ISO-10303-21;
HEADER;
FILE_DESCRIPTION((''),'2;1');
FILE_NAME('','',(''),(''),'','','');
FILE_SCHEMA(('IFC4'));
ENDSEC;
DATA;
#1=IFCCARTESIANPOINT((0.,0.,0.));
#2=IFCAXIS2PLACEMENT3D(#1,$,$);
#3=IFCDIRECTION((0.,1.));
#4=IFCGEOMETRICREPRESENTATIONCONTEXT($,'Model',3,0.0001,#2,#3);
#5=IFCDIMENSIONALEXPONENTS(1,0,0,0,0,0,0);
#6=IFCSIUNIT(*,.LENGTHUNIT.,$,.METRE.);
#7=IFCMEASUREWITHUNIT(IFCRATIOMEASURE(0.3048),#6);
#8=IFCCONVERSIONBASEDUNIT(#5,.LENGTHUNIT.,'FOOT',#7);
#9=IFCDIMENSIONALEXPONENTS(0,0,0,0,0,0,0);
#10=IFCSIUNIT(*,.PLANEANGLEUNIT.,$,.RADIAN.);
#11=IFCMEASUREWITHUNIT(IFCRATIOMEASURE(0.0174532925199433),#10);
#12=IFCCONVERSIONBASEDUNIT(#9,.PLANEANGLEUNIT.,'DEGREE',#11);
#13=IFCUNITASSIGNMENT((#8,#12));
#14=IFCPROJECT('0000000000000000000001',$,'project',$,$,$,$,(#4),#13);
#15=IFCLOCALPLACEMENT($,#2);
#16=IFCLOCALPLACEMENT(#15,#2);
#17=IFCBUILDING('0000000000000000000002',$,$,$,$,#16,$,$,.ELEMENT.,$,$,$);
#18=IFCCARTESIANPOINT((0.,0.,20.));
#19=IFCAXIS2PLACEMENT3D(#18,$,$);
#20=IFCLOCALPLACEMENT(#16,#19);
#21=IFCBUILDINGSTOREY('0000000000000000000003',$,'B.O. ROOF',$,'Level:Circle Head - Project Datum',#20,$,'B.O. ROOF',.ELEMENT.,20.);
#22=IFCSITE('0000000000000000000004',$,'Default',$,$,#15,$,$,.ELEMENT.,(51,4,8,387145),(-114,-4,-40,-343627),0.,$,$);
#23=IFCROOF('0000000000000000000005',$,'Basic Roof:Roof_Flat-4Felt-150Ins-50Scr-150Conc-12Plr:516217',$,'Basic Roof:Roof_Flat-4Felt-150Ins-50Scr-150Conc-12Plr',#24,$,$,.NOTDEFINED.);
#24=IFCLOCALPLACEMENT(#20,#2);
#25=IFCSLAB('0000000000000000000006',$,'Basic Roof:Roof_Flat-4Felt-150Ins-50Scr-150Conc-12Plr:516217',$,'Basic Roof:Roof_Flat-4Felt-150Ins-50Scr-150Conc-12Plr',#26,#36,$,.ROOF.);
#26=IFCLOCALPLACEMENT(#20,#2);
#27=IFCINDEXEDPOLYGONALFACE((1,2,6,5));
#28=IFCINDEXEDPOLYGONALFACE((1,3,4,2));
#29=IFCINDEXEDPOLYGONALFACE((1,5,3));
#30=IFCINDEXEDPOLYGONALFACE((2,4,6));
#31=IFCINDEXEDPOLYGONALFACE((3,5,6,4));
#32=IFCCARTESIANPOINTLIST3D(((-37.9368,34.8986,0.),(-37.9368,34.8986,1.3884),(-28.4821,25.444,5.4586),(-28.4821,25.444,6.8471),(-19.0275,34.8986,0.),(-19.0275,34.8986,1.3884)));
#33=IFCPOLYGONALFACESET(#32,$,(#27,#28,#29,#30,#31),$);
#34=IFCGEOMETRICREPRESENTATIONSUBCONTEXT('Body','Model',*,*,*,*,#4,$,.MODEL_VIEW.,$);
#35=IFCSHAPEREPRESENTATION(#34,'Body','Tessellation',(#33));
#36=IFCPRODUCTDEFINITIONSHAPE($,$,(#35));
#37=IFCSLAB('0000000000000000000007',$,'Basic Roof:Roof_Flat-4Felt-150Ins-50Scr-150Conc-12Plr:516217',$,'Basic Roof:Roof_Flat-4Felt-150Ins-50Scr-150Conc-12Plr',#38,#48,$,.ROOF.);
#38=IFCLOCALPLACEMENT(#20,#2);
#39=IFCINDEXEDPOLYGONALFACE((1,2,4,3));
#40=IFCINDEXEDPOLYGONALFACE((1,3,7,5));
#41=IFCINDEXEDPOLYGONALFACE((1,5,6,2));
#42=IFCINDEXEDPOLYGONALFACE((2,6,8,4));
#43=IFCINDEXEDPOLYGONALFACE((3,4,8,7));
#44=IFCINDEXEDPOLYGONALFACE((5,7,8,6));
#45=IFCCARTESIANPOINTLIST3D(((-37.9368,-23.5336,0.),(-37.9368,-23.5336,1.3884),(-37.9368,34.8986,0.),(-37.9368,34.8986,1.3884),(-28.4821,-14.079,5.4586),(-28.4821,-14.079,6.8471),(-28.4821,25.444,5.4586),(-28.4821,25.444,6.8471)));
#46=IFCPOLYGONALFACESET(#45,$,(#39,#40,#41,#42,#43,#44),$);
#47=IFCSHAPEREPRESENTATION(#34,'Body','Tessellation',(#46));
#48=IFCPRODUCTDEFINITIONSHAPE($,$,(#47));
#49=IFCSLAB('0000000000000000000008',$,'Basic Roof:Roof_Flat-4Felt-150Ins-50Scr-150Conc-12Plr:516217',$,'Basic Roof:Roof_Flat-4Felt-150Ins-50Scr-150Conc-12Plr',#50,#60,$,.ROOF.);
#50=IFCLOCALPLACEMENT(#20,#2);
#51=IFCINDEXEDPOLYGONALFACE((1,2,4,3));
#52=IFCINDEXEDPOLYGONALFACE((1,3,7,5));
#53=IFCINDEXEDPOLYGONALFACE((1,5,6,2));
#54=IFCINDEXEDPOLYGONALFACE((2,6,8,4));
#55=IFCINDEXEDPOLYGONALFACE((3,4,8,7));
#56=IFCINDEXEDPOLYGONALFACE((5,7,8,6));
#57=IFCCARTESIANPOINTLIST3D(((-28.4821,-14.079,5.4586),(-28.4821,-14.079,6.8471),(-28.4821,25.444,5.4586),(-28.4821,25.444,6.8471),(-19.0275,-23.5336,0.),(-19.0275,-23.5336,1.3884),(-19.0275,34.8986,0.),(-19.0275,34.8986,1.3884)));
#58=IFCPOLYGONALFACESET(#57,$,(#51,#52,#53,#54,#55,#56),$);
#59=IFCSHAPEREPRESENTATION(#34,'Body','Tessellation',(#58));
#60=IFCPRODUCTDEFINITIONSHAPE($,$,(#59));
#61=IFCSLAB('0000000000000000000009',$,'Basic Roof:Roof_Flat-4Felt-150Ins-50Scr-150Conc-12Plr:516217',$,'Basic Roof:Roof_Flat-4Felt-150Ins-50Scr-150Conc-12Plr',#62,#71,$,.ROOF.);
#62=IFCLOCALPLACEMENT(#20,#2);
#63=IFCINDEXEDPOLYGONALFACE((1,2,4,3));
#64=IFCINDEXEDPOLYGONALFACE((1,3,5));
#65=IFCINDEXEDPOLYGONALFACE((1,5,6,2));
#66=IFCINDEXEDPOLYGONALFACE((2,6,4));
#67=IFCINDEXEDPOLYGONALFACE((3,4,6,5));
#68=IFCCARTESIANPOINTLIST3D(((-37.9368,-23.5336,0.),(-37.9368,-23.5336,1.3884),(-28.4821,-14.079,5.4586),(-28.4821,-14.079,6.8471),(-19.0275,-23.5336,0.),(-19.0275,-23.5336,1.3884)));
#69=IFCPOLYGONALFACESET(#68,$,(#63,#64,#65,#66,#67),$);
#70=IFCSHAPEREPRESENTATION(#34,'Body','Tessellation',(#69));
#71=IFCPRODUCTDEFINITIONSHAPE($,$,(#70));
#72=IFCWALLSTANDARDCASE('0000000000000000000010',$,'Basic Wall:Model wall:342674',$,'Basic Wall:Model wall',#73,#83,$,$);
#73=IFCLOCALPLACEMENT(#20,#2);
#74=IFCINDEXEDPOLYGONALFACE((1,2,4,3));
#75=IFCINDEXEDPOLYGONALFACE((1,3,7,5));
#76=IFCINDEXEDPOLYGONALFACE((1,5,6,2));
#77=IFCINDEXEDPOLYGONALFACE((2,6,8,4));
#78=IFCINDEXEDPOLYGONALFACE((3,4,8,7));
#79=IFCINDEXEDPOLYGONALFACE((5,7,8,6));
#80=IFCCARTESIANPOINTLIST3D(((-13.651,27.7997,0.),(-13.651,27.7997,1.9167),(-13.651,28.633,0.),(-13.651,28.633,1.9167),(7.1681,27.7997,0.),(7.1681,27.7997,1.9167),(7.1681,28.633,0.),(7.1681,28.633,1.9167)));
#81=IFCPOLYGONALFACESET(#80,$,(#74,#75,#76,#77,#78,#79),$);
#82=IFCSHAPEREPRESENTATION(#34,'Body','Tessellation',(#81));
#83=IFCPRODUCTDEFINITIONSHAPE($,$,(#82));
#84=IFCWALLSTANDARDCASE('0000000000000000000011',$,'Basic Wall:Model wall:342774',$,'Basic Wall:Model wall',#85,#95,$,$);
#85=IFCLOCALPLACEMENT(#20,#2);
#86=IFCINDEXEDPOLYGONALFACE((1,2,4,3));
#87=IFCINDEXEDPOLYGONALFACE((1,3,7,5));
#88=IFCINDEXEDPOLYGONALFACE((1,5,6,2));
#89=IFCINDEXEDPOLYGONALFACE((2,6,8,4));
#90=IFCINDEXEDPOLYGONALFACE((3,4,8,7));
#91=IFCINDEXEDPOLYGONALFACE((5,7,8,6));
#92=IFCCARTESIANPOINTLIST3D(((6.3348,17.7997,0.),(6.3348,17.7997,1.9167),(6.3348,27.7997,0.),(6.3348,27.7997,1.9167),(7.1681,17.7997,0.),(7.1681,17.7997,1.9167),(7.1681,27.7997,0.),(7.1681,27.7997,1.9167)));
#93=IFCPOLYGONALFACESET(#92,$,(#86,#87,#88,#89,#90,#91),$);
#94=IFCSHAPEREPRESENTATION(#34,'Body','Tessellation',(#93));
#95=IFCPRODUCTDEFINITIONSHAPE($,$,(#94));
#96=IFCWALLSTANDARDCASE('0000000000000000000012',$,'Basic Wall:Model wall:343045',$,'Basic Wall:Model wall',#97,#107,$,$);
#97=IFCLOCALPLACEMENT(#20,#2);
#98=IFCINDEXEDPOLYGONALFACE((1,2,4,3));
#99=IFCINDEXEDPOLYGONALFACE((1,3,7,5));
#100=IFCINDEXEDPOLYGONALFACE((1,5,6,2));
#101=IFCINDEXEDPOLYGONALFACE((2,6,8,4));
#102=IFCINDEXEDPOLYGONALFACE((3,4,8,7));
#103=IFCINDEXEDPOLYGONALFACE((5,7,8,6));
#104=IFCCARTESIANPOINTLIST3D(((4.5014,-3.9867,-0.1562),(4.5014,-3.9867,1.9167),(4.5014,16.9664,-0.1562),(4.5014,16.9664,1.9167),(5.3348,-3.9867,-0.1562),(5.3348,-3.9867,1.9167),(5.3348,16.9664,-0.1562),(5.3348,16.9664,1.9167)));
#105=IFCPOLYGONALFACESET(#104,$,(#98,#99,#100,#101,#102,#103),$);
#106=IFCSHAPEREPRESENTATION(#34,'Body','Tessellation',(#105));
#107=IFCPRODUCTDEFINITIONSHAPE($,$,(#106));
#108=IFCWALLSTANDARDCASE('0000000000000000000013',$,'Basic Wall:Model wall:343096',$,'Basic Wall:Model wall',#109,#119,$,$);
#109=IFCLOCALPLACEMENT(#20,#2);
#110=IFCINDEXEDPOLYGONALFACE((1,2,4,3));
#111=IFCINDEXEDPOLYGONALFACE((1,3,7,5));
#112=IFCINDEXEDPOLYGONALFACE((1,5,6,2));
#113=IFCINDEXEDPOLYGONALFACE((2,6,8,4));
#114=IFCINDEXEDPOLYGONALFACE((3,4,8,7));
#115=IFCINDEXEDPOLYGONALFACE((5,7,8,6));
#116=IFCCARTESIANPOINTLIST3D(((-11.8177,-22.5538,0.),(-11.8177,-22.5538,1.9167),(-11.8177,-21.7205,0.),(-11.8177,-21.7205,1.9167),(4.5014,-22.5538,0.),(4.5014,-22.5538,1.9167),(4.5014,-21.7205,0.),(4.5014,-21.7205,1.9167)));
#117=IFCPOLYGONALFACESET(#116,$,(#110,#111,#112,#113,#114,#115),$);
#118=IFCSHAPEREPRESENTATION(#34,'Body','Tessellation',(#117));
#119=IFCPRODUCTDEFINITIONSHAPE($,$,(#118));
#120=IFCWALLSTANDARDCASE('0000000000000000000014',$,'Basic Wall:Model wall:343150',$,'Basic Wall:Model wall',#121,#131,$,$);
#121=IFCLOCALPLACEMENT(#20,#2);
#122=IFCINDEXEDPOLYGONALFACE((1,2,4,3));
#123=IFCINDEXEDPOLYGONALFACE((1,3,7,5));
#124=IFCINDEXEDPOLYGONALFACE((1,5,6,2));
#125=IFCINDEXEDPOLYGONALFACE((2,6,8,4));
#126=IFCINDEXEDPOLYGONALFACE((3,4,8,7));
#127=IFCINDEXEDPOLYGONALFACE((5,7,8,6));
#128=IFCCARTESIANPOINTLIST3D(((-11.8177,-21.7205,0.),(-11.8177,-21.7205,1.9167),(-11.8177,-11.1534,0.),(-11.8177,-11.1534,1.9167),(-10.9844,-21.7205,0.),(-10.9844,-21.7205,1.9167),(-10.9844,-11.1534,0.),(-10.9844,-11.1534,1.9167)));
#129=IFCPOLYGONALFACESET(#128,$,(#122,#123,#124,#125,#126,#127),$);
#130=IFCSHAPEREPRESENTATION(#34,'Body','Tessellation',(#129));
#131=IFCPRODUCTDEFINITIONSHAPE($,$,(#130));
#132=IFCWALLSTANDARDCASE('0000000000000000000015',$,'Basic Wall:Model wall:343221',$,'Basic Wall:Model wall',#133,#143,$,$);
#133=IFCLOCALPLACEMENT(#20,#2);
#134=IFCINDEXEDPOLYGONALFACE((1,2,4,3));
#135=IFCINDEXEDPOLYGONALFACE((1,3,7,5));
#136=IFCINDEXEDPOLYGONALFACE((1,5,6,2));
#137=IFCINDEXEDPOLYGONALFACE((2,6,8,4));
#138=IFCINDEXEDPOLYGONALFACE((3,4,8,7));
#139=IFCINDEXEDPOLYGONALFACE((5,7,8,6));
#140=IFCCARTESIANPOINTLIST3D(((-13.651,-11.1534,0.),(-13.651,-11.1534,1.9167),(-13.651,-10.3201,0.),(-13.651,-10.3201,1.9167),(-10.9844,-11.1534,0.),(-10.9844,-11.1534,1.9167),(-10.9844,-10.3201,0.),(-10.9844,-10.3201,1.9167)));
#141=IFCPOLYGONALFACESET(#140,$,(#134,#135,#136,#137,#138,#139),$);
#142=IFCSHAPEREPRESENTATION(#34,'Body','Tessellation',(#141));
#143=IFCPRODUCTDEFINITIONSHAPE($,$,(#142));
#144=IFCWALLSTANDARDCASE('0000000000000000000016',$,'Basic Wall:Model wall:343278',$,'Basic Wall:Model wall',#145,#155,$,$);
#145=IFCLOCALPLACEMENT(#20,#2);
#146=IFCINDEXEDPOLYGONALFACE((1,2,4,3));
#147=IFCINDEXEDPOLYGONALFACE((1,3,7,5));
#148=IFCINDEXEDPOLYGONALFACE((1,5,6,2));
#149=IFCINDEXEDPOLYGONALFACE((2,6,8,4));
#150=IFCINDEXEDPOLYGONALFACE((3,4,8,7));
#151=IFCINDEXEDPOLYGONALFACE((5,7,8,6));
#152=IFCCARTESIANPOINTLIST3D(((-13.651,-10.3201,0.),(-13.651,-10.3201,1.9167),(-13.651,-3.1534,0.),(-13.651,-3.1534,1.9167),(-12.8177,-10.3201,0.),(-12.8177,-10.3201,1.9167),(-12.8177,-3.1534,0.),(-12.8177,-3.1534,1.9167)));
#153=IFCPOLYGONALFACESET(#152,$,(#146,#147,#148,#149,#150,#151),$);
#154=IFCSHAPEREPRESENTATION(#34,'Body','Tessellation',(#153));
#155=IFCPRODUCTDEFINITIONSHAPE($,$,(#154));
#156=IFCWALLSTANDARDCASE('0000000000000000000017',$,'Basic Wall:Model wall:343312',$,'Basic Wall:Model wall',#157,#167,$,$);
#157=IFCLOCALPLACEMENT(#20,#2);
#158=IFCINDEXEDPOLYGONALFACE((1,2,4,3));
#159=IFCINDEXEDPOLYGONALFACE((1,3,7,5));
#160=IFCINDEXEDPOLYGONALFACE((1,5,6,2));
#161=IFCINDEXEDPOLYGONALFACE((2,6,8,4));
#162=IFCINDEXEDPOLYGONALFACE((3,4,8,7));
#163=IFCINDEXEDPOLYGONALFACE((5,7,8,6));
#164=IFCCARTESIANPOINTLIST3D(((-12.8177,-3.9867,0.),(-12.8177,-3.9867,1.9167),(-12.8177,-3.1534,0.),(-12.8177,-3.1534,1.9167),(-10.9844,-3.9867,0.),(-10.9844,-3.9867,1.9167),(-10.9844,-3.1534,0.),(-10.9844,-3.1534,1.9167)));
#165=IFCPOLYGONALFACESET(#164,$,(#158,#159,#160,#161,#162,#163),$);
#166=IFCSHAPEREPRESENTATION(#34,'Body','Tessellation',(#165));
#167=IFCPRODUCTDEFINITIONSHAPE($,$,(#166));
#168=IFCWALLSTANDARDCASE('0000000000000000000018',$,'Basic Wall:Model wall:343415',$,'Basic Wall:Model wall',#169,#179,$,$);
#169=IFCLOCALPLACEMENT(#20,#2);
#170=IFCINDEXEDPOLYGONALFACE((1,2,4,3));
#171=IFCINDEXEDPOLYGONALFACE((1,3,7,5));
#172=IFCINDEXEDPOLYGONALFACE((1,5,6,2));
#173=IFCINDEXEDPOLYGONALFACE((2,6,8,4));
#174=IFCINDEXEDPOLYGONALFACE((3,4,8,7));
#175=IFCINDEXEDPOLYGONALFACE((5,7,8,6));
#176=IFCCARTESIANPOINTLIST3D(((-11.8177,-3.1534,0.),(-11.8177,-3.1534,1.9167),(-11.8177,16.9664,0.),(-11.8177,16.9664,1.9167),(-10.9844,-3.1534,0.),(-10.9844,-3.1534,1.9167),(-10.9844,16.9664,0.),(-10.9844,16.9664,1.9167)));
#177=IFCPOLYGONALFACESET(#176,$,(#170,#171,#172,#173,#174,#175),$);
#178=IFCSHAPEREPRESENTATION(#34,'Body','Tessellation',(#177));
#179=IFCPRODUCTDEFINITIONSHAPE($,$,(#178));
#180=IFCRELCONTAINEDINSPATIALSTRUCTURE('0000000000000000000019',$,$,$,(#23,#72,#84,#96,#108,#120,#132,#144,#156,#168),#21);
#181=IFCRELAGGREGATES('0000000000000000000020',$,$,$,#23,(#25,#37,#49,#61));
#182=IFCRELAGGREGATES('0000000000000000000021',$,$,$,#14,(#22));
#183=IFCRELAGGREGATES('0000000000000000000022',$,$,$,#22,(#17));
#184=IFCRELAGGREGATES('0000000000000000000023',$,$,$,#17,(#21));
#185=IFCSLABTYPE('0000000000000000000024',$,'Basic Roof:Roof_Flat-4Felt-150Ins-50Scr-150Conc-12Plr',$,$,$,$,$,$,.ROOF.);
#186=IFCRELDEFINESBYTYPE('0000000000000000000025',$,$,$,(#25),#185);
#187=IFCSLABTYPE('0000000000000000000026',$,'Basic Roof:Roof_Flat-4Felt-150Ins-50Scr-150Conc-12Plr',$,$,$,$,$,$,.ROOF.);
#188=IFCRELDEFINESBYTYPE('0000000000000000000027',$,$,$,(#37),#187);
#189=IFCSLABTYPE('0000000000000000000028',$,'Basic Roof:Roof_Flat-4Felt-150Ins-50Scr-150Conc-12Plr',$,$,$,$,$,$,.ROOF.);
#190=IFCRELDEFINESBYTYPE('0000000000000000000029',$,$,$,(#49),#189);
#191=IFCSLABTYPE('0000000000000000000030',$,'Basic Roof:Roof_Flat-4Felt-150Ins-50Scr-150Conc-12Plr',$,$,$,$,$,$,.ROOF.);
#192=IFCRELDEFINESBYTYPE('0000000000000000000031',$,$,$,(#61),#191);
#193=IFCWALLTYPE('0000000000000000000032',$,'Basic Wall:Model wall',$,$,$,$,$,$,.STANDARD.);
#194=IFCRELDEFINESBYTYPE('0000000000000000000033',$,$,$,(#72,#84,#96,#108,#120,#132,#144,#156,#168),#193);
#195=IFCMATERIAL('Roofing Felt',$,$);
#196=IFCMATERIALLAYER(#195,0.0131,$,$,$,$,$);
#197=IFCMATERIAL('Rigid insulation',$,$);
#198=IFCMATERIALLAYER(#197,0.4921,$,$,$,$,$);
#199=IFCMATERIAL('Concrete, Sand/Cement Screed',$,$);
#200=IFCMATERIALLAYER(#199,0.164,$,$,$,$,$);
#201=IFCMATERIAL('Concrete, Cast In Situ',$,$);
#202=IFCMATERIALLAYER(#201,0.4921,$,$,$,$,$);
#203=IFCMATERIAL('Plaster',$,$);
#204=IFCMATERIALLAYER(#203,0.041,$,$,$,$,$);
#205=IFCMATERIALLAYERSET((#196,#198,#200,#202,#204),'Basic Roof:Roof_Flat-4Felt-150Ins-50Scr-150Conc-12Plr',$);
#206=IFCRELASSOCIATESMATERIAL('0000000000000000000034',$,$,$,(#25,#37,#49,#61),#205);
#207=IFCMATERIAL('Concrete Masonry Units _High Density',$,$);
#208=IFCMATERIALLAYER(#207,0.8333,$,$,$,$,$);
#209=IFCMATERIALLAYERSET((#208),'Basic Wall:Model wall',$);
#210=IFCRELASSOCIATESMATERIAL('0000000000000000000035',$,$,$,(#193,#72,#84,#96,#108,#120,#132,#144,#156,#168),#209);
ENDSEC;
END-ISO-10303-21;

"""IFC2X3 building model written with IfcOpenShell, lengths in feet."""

from ifc_helpers import new_model, entity, si_unit, converted_unit, direction, frame, frame_2d, origin, place, context, subcontext, project, spatial, polyline, rectangle, outline, extrude, material, layer, layer_set, layer_usage, type_object, element, aggregate, save


model = new_model("IFC2X3")

# Units and contexts
model_context = context("Model", 3, precision=0.0001, world=origin(), true_north=direction((0.0, 1.0)))
body_context = subcontext(model_context, "Body", "Model", "MODEL_VIEW")
ifc_project = project(units=[converted_unit("LENGTHUNIT", "FOOT", entity("IfcRatioMeasure", 0.3048), si_unit("LENGTHUNIT", "METRE"), dimensions=[1, 0, 0, 0, 0, 0, 0]), converted_unit("PLANEANGLEUNIT", "DEGREE", entity("IfcRatioMeasure", 0.0174532925199433), si_unit("PLANEANGLEUNIT", "RADIAN"), dimensions=[0, 0, 0, 0, 0, 0, 0])], contexts=[model_context])

# Site, building, storey
site_placement = place(None, origin())
site = spatial("IfcSite", under=ifc_project, at=site_placement, Name="Default", CompositionType="ELEMENT", RefLatitude=(51, 4, 8, 387145), RefLongitude=(-114, -4, -40, -343627), RefElevation=0.0)
building_placement = place(site_placement, origin())
building = spatial("IfcBuilding", under=site, at=building_placement, CompositionType="ELEMENT")
storey_placement = place(building_placement, frame((0.0, 0.0, 20.0)))
storey = spatial("IfcBuildingStorey", under=building, at=storey_placement, Name="B.O. ROOF", ObjectType="Level:Circle Head - Project Datum", LongName="B.O. ROOF", CompositionType="ELEMENT", Elevation=20.0)

# Shared definitions
ifc_material_1 = material(Name="Rigid insulation")

# Roof, slabs
roof_1_placement = place(storey_placement, frame((-37.9368, -23.5336, 0.0)))
roof_1 = element("IfcRoof", 1, at=roof_1_placement, inside=storey, Name="Basic Roof:Roof_Flat-4Felt-150Ins-50Scr-150Conc-12Plr:516217", ObjectType="Basic Roof:Roof_Flat-4Felt-150Ins-50Scr-150Conc-12Plr", ShapeType="NOTDEFINED")
ifc_material_2 = material(Name="Roofing Felt")
ifc_layer_1 = layer(ifc_material_2, 0.0131)
ifc_layer_2 = layer(ifc_material_1, 0.4921)
ifc_material_3 = material(Name="Concrete, Sand/Cement Screed")
ifc_layer_3 = layer(ifc_material_3, 0.164)
ifc_material_4 = material(Name="Concrete, Cast In Situ")
ifc_layer_4 = layer(ifc_material_4, 0.4921)
ifc_material_5 = material(Name="Plaster")
ifc_layer_5 = layer(ifc_material_5, 0.041)
ifc_layer_set_1 = layer_set([ifc_layer_1, ifc_layer_2, ifc_layer_3, ifc_layer_4, ifc_layer_5], Name="Basic Roof:Roof_Flat-4Felt-150Ins-50Scr-150Conc-12Plr")
slab_type_1 = type_object("IfcSlabType", Name="Basic Roof:Roof_Flat-4Felt-150Ins-50Scr-150Conc-12Plr", PredefinedType="ROOF")
slab_1_placement = place(roof_1_placement, origin())
slab_1 = element("IfcSlab", 2, at=slab_1_placement, type_object=slab_type_1, material=ifc_layer_set_1, Name="Basic Roof:Roof_Flat-4Felt-150Ins-50Scr-150Conc-12Plr:516217", ObjectType="Basic Roof:Roof_Flat-4Felt-150Ins-50Scr-150Conc-12Plr", PredefinedType="ROOF", context=body_context, shape_type="SweptSolid", body=[
    extrude(outline(polyline([(9.4547, 5.4586), (-9.4547, 5.4586), (0.0, -5.4586), (9.4547, 5.4586)])), frame((9.4547, 53.7049, 2.7293), z_axis=(0.0, 0.5, 0.866025), x_axis=(1.0, 0.0, 0.0)), (0.0, -0.5, 0.866025), 1.3884),
])
slab_type_2 = type_object("IfcSlabType", Name="Basic Roof:Roof_Flat-4Felt-150Ins-50Scr-150Conc-12Plr", PredefinedType="ROOF")
slab_2_placement = place(roof_1_placement, origin())
slab_2 = element("IfcSlab", 3, at=slab_2_placement, type_object=slab_type_2, material=ifc_layer_set_1, Name="Basic Roof:Roof_Flat-4Felt-150Ins-50Scr-150Conc-12Plr:516217", ObjectType="Basic Roof:Roof_Flat-4Felt-150Ins-50Scr-150Conc-12Plr", PredefinedType="ROOF", context=body_context, shape_type="SweptSolid", body=[
    extrude(outline(polyline([(-5.4586, 29.2161), (-5.4586, -29.2161), (5.4586, -19.7615), (5.4586, 19.7615), (-5.4586, 29.2161)])), frame((4.7273, 29.2161, 2.7293), z_axis=(-0.5, 0.0, 0.866025), x_axis=(0.866025, 0.0, 0.5)), (0.5, 0.0, 0.866025), 1.3884),
])
slab_type_3 = type_object("IfcSlabType", Name="Basic Roof:Roof_Flat-4Felt-150Ins-50Scr-150Conc-12Plr", PredefinedType="ROOF")
slab_3_placement = place(roof_1_placement, origin())
slab_3 = element("IfcSlab", 4, at=slab_3_placement, type_object=slab_type_3, material=ifc_layer_set_1, Name="Basic Roof:Roof_Flat-4Felt-150Ins-50Scr-150Conc-12Plr:516217", ObjectType="Basic Roof:Roof_Flat-4Felt-150Ins-50Scr-150Conc-12Plr", PredefinedType="ROOF", context=body_context, shape_type="SweptSolid", body=[
    extrude(outline(polyline([(-5.4586, 19.7615), (-5.4586, -19.7615), (5.4586, -29.2161), (5.4586, 29.2161), (-5.4586, 19.7615)])), frame((14.182, 29.2161, 2.7293), z_axis=(0.5, 0.0, 0.866025), x_axis=(0.866025, 0.0, -0.5)), (-0.5, 0.0, 0.866025), 1.3884),
])
slab_type_4 = type_object("IfcSlabType", Name="Basic Roof:Roof_Flat-4Felt-150Ins-50Scr-150Conc-12Plr", PredefinedType="ROOF")
slab_4_placement = place(roof_1_placement, origin())
slab_4 = element("IfcSlab", 5, at=slab_4_placement, type_object=slab_type_4, material=ifc_layer_set_1, Name="Basic Roof:Roof_Flat-4Felt-150Ins-50Scr-150Conc-12Plr:516217", ObjectType="Basic Roof:Roof_Flat-4Felt-150Ins-50Scr-150Conc-12Plr", PredefinedType="ROOF", context=body_context, shape_type="SweptSolid", body=[
    extrude(outline(polyline([(-9.4547, -5.4586), (9.4547, -5.4586), (0.0, 5.4586), (-9.4547, -5.4586)])), frame((9.4547, 4.7273, 2.7293), z_axis=(0.0, -0.5, 0.866025), x_axis=(1.0, 0.0, 0.0)), (0.0, 0.5, 0.866025), 1.3884),
])
aggregate(roof_1, [slab_1, slab_2, slab_3, slab_4])

# Walls
ifc_material_6 = material(Name="Concrete Masonry Units _High Density")
ifc_layer_6 = layer(ifc_material_6, 0.8333)
ifc_layer_set_2 = layer_set([ifc_layer_6], Name="Basic Wall:Model wall")
ifc_layer_usage_1 = layer_usage(ifc_layer_set_2, "AXIS2", "NEGATIVE", 0.4167)
wall_type = type_object("IfcWallType", Name="Basic Wall:Model wall", PredefinedType="STANDARD", material=ifc_layer_set_2)
wall_1_placement = place(storey_placement, frame((-13.651, 28.2164, 0.0)))
element("IfcWallStandardCase", 6, at=wall_1_placement, inside=storey, type_object=wall_type, material=ifc_layer_usage_1, Name="Basic Wall:Model wall:342674", ObjectType="Basic Wall:Model wall", context=body_context, shape_type="SweptSolid", body=[
    extrude(rectangle(XDim=20.8192, YDim=0.8333, at=frame_2d((10.4096, 0.0), x_axis=(-1.0, 0.0))), origin(), (0.0, 0.0, 1.0), 1.9167),
])
ifc_layer_usage_2 = layer_usage(ifc_layer_set_2, "AXIS2", "NEGATIVE", 0.4167)
wall_2_placement = place(storey_placement, frame((6.7514, 27.7997, 0.0), z_axis=(0.0, 0.0, 1.0), x_axis=(0.0, -1.0, 0.0)))
element("IfcWallStandardCase", 7, at=wall_2_placement, inside=storey, type_object=wall_type, material=ifc_layer_usage_2, Name="Basic Wall:Model wall:342774", ObjectType="Basic Wall:Model wall", context=body_context, shape_type="SweptSolid", body=[
    extrude(rectangle(XDim=10.0, YDim=0.8333, at=frame_2d((5.0, 0.0), x_axis=(-1.0, 0.0))), origin(), (0.0, 0.0, 1.0), 1.9167),
])
ifc_layer_usage_3 = layer_usage(ifc_layer_set_2, "AXIS2", "NEGATIVE", 0.4167)
wall_3_placement = place(storey_placement, frame((4.9181, 16.9664, -0.1562), z_axis=(0.0, 0.0, 1.0), x_axis=(0.0, -1.0, 0.0)))
element("IfcWallStandardCase", 8, at=wall_3_placement, inside=storey, type_object=wall_type, material=ifc_layer_usage_3, Name="Basic Wall:Model wall:343045", ObjectType="Basic Wall:Model wall", context=body_context, shape_type="SweptSolid", body=[
    extrude(rectangle(XDim=20.9531, YDim=0.8333, at=frame_2d((10.4766, 0.0), x_axis=(-1.0, 0.0))), origin(), (0.0, 0.0, 1.0), 2.0728),
])
ifc_layer_usage_4 = layer_usage(ifc_layer_set_2, "AXIS2", "NEGATIVE", 0.4167)
wall_4_placement = place(storey_placement, frame((4.5014, -22.1371, 0.0), z_axis=(0.0, 0.0, 1.0), x_axis=(-1.0, 0.0, 0.0)))
element("IfcWallStandardCase", 9, at=wall_4_placement, inside=storey, type_object=wall_type, material=ifc_layer_usage_4, Name="Basic Wall:Model wall:343096", ObjectType="Basic Wall:Model wall", context=body_context, shape_type="SweptSolid", body=[
    extrude(rectangle(XDim=16.3192, YDim=0.8333, at=frame_2d((8.1596, 0.0), x_axis=(-1.0, 0.0))), origin(), (0.0, 0.0, 1.0), 1.9167),
])
ifc_layer_usage_5 = layer_usage(ifc_layer_set_2, "AXIS2", "NEGATIVE", 0.4167)
wall_5_placement = place(storey_placement, frame((-11.401, -21.7205, 0.0), z_axis=(0.0, 0.0, 1.0), x_axis=(0.0, 1.0, 0.0)))
element("IfcWallStandardCase", 10, at=wall_5_placement, inside=storey, type_object=wall_type, material=ifc_layer_usage_5, Name="Basic Wall:Model wall:343150", ObjectType="Basic Wall:Model wall", context=body_context, shape_type="SweptSolid", body=[
    extrude(rectangle(XDim=10.5671, YDim=0.8333, at=frame_2d((5.2835, 0.0), x_axis=(-1.0, 0.0))), origin(), (0.0, 0.0, 1.0), 1.9167),
])
ifc_layer_usage_6 = layer_usage(ifc_layer_set_2, "AXIS2", "NEGATIVE", 0.4167)
wall_6_placement = place(storey_placement, frame((-10.9844, -10.7367, 0.0), z_axis=(0.0, 0.0, 1.0), x_axis=(-1.0, 0.0, 0.0)))
element("IfcWallStandardCase", 11, at=wall_6_placement, inside=storey, type_object=wall_type, material=ifc_layer_usage_6, Name="Basic Wall:Model wall:343221", ObjectType="Basic Wall:Model wall", context=body_context, shape_type="SweptSolid", body=[
    extrude(rectangle(XDim=2.6667, YDim=0.8333, at=frame_2d((1.3333, 0.0), x_axis=(-1.0, 0.0))), origin(), (0.0, 0.0, 1.0), 1.9167),
])
ifc_layer_usage_7 = layer_usage(ifc_layer_set_2, "AXIS2", "NEGATIVE", 0.4167)
wall_7_placement = place(storey_placement, frame((-13.2344, -10.3201, 0.0), z_axis=(0.0, 0.0, 1.0), x_axis=(0.0, 1.0, 0.0)))
element("IfcWallStandardCase", 12, at=wall_7_placement, inside=storey, type_object=wall_type, material=ifc_layer_usage_7, Name="Basic Wall:Model wall:343278", ObjectType="Basic Wall:Model wall", context=body_context, shape_type="SweptSolid", body=[
    extrude(rectangle(XDim=7.1667, YDim=0.8333, at=frame_2d((3.5833, 0.0), x_axis=(-1.0, 0.0))), origin(), (0.0, 0.0, 1.0), 1.9167),
])
ifc_layer_usage_8 = layer_usage(ifc_layer_set_2, "AXIS2", "NEGATIVE", 0.4167)
wall_8_placement = place(storey_placement, frame((-12.8177, -3.5701, 0.0)))
element("IfcWallStandardCase", 13, at=wall_8_placement, inside=storey, type_object=wall_type, material=ifc_layer_usage_8, Name="Basic Wall:Model wall:343312", ObjectType="Basic Wall:Model wall", context=body_context, shape_type="SweptSolid", body=[
    extrude(rectangle(XDim=1.8333, YDim=0.8333, at=frame_2d((0.9167, 0.0), x_axis=(-1.0, 0.0))), origin(), (0.0, 0.0, 1.0), 1.9167),
])
ifc_layer_usage_9 = layer_usage(ifc_layer_set_2, "AXIS2", "NEGATIVE", 0.4167)
wall_9_placement = place(storey_placement, frame((-11.401, -3.1534, 0.0), z_axis=(0.0, 0.0, 1.0), x_axis=(0.0, 1.0, 0.0)))
element("IfcWallStandardCase", 14, at=wall_9_placement, inside=storey, type_object=wall_type, material=ifc_layer_usage_9, Name="Basic Wall:Model wall:343415", ObjectType="Basic Wall:Model wall", context=body_context, shape_type="SweptSolid", body=[
    extrude(rectangle(XDim=20.1198, YDim=0.8333, at=frame_2d((10.0599, 0.0), x_axis=(-1.0, 0.0))), origin(), (0.0, 0.0, 1.0), 1.9167),
])

save(model, "model.ifc")
